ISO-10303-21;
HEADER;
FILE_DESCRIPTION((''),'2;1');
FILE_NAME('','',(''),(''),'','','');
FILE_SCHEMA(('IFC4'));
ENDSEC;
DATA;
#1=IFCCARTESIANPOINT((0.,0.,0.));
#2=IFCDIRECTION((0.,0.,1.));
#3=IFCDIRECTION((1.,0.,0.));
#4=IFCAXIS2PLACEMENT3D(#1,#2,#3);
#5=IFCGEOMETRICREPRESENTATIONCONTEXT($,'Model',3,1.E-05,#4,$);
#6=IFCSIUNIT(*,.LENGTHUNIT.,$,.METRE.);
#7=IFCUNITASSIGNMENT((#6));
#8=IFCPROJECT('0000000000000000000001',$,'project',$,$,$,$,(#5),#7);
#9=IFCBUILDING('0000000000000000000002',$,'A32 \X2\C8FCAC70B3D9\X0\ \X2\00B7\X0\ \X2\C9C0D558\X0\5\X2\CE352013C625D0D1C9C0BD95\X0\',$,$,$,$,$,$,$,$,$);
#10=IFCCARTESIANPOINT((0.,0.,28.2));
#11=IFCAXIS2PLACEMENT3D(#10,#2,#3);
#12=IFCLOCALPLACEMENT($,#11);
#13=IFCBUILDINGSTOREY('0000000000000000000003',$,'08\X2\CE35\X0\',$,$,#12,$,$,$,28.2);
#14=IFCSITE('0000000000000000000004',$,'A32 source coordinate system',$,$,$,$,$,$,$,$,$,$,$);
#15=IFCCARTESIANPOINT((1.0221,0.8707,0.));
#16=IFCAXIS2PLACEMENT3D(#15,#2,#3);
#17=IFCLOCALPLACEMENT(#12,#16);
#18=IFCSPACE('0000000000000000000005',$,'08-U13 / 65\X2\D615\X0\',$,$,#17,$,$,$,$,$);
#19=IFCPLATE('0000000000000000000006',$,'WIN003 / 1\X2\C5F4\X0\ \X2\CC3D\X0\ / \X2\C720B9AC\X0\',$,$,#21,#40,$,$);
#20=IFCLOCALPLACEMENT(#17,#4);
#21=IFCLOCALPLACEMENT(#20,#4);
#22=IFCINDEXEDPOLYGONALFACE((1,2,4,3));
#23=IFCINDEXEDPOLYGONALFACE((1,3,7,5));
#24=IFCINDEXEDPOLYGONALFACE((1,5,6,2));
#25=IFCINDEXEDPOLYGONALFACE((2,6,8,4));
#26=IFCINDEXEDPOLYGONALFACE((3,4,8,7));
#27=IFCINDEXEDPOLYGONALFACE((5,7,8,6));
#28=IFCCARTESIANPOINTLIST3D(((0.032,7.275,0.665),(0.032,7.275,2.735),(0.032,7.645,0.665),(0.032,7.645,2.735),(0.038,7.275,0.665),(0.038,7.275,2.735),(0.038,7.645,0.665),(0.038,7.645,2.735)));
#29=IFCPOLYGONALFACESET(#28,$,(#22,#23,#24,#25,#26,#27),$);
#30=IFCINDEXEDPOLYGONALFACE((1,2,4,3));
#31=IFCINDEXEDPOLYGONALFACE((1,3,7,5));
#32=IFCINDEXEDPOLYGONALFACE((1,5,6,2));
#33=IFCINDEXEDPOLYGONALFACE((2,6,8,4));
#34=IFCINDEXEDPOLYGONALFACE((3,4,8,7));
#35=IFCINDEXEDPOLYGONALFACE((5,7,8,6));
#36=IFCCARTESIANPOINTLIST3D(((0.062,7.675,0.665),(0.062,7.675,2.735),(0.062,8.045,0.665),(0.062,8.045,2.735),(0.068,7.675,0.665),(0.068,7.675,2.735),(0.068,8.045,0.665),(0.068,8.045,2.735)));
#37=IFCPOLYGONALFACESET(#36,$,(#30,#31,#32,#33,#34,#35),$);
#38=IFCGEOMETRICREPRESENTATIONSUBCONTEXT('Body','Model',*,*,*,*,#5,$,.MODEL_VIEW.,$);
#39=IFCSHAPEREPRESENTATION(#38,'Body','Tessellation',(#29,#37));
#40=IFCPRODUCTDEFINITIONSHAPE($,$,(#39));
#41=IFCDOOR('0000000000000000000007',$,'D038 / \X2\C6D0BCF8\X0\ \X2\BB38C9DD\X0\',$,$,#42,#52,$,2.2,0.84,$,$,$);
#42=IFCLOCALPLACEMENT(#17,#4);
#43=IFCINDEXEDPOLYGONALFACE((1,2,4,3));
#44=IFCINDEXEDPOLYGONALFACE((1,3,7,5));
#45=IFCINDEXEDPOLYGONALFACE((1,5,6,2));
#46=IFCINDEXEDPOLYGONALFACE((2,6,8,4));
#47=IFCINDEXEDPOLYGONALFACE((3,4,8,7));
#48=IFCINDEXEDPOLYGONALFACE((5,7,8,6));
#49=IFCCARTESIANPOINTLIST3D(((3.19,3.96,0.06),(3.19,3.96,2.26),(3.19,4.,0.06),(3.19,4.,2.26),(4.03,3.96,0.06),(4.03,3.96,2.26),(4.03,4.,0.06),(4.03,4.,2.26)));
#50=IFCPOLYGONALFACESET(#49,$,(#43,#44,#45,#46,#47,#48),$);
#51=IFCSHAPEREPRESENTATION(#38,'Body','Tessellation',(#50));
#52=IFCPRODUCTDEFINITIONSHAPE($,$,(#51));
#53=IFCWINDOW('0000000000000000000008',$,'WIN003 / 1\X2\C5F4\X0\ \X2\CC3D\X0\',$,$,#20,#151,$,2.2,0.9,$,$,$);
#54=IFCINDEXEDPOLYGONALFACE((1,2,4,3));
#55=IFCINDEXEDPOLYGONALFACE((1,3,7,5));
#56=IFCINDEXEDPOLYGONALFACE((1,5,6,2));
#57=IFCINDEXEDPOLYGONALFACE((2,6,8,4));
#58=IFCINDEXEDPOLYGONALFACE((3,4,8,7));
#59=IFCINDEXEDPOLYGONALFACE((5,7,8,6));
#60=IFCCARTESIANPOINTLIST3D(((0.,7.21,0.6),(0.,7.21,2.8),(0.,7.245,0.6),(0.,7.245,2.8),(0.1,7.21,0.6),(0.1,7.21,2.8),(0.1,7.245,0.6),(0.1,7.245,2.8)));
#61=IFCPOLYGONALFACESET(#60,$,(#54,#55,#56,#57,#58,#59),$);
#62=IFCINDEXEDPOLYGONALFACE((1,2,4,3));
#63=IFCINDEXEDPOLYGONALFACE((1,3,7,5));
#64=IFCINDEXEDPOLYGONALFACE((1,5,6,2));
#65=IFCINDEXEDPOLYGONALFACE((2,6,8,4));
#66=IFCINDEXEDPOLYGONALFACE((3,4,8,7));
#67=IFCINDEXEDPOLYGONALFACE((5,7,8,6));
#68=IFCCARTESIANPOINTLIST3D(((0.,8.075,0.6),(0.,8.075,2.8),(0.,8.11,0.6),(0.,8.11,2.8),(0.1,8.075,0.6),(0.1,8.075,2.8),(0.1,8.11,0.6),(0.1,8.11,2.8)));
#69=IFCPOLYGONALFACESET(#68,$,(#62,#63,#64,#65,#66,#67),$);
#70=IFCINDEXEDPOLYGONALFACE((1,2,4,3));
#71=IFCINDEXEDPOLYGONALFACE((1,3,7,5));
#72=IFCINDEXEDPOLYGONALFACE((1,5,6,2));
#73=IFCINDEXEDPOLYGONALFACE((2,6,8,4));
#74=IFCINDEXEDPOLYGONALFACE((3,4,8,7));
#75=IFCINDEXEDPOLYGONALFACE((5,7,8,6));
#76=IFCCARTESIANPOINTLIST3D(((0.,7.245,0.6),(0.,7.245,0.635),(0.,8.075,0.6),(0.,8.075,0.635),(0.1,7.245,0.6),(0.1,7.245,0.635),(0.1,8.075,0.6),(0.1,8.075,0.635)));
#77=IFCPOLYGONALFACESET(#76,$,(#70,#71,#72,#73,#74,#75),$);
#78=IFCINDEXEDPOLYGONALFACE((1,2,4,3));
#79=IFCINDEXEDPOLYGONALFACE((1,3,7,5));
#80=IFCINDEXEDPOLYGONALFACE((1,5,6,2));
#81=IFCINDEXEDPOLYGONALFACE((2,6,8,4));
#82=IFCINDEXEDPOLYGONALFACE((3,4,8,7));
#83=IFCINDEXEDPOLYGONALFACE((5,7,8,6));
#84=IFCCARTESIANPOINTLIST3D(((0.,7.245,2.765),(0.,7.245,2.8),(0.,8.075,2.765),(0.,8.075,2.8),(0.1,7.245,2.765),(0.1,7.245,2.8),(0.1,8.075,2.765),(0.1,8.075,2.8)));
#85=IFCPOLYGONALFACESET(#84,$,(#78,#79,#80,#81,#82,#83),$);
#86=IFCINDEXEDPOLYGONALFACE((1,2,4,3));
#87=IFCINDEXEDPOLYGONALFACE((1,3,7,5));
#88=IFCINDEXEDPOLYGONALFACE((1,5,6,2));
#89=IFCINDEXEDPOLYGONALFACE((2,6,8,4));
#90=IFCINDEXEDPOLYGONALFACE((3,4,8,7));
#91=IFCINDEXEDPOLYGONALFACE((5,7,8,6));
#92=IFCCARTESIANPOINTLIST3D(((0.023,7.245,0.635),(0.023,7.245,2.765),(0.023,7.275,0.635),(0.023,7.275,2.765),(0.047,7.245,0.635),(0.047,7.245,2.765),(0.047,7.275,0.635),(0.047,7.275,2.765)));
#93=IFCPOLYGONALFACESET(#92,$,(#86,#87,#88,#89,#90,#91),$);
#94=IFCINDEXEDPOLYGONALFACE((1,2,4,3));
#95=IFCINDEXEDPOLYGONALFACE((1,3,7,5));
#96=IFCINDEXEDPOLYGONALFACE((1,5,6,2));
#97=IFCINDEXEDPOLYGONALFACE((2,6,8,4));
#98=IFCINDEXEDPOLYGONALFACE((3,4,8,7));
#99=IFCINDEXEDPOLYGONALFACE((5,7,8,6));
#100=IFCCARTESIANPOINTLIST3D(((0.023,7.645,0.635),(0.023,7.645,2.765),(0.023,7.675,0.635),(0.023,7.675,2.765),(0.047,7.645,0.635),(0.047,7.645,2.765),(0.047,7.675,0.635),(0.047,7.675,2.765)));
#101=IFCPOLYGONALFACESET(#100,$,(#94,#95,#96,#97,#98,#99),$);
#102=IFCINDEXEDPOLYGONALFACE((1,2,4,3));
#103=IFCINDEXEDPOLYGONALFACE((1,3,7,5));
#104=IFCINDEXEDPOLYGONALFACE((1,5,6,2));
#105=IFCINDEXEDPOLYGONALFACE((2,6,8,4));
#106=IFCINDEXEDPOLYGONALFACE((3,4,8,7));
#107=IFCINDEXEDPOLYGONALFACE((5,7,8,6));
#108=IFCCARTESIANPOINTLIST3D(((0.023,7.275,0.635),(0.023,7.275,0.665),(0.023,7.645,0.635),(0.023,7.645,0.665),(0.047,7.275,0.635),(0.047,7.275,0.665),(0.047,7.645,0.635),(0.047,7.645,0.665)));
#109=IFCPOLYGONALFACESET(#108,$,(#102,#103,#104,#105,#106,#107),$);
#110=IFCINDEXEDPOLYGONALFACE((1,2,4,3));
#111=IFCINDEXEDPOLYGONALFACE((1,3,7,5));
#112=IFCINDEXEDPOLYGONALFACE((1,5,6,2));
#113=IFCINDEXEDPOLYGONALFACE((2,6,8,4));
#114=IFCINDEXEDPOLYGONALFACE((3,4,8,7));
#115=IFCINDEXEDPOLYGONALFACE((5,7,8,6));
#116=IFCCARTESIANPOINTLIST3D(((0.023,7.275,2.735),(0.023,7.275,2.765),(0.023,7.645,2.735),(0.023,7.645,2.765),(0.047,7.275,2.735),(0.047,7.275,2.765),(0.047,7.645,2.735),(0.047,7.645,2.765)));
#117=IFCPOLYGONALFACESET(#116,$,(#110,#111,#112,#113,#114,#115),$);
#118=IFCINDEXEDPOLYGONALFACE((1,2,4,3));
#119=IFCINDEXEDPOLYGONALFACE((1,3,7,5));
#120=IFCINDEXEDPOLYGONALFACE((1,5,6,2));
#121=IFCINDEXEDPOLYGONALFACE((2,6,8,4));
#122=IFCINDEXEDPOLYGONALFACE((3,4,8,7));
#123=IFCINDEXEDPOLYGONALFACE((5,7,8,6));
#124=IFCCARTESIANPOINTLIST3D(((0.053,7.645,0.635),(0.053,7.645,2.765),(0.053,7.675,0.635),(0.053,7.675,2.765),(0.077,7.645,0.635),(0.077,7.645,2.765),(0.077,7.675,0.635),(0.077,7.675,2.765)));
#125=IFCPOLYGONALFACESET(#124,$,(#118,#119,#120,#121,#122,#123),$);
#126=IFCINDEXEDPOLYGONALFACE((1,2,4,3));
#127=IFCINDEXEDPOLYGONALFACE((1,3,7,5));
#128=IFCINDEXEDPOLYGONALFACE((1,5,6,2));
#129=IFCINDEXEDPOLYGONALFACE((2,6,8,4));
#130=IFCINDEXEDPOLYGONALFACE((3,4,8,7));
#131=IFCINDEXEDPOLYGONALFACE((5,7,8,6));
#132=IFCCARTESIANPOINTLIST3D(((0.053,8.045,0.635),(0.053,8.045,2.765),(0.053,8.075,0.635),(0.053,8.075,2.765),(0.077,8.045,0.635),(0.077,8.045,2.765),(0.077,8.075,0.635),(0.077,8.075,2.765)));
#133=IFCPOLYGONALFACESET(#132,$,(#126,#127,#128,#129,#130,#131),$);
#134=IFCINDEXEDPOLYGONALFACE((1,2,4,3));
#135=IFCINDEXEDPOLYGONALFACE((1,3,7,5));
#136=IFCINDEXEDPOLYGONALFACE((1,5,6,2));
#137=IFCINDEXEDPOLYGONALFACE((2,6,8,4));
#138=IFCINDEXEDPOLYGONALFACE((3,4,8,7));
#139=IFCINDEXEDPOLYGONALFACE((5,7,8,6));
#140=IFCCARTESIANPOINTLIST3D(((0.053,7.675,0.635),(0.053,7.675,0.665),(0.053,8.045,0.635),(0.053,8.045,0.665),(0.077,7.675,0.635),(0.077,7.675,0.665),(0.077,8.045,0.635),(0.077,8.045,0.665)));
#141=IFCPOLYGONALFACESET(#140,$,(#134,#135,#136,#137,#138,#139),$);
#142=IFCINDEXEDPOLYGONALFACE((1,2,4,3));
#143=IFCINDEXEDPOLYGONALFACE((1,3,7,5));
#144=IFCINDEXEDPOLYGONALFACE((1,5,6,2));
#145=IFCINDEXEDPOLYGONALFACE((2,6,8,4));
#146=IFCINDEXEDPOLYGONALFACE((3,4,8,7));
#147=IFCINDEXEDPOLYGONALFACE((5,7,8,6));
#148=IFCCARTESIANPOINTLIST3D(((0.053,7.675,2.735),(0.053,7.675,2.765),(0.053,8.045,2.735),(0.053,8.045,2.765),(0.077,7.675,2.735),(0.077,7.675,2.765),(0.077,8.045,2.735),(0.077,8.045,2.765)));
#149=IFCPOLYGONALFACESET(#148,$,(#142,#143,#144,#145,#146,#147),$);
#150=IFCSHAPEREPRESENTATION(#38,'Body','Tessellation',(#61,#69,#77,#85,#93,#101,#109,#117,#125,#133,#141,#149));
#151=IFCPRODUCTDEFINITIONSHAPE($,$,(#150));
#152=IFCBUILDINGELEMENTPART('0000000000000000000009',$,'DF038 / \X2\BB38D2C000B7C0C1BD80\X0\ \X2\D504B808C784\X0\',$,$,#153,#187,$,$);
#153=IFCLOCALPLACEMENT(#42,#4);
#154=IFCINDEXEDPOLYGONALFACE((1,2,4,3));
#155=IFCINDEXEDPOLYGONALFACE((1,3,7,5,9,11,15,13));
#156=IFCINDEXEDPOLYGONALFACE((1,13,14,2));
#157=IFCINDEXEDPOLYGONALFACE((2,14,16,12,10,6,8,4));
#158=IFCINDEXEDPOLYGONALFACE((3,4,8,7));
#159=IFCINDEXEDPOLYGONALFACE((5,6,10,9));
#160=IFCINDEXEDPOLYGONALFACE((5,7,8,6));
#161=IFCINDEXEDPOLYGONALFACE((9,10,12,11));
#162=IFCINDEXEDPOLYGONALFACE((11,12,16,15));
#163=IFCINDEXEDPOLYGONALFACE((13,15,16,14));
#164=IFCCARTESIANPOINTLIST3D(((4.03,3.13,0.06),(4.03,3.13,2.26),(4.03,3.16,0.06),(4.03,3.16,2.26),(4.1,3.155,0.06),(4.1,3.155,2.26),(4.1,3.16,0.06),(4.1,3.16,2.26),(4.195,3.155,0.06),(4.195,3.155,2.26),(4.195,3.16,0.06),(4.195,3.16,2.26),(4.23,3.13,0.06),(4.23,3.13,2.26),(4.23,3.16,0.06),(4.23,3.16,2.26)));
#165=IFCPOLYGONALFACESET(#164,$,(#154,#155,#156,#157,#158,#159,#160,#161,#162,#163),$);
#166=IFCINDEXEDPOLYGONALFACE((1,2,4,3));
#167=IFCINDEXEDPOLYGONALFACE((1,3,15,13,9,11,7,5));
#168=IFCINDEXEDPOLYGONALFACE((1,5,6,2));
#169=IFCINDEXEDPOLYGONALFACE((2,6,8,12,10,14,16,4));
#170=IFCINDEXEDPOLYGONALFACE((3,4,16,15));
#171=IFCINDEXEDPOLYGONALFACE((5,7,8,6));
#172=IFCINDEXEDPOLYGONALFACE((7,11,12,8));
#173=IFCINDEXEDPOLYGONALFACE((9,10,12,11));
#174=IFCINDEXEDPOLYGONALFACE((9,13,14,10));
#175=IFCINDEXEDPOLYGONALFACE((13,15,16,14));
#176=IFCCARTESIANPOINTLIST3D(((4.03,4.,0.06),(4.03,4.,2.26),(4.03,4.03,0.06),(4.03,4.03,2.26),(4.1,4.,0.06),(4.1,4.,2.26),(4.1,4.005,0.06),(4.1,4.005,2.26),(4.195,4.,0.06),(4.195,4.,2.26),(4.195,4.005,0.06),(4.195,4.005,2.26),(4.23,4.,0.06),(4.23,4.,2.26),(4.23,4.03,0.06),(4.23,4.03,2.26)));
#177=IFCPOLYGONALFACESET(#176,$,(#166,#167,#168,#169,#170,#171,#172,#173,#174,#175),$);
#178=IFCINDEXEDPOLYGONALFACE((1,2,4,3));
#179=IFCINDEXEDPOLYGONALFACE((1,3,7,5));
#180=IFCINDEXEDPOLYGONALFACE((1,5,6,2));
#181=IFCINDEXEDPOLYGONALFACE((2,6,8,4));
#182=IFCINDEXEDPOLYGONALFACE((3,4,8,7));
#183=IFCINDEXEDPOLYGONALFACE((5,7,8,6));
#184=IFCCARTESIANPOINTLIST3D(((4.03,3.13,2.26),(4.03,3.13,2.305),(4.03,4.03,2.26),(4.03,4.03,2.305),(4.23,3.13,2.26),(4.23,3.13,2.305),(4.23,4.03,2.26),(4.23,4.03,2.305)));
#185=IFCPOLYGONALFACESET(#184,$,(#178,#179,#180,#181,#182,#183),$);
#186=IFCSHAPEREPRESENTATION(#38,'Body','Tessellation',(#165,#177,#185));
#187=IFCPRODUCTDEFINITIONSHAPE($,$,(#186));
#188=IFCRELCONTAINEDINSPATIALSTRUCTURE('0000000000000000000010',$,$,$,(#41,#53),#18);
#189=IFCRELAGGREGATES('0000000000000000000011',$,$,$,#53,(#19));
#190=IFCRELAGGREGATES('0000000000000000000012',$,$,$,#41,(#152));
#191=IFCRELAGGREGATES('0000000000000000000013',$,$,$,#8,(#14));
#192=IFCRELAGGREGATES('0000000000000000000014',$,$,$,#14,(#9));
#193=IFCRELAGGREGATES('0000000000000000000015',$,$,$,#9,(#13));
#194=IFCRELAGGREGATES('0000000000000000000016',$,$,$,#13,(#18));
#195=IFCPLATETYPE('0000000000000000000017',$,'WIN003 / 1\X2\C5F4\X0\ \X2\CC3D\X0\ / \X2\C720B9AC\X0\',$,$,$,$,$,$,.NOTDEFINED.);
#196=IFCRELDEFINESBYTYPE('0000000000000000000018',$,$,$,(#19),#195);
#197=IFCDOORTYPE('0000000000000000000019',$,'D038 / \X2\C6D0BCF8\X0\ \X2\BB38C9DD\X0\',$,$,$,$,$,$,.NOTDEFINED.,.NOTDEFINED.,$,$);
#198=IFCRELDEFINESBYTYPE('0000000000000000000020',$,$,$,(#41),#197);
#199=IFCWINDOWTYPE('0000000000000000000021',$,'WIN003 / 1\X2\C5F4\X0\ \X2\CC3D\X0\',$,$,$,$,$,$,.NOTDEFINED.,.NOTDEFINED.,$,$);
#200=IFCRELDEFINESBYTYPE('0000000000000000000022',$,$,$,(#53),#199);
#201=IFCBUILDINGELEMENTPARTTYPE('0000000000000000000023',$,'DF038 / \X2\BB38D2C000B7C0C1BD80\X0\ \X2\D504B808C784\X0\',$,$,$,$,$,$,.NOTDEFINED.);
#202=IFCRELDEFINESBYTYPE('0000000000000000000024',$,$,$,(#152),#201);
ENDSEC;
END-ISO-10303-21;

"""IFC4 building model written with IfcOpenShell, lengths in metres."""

from ifc_helpers import new_model, si_unit, frame, origin, origin_with_axes, place, context, subcontext, project, spatial, polyline, outline, extrude, source, transform, mapped, type_object, type_shapes, element, aggregate, save


model = new_model("IFC4")

# Units and contexts
model_context = context("Model", 3, precision=1e-05, world=origin_with_axes())
body_context = subcontext(model_context, "Body", "Model", "MODEL_VIEW")
ifc_project = project(units=[si_unit("LENGTHUNIT", "METRE")], contexts=[model_context])

# Plate
storey_placement = place(None, frame((0.0, 0.0, 28.2), z_axis=(0.0, 0.0, 1.0), x_axis=(1.0, 0.0, 0.0)))
space_placement = place(storey_placement, frame((1.0221, 0.8707, 0.0), z_axis=(0.0, 0.0, 1.0), x_axis=(1.0, 0.0, 0.0)))
plate_type_1 = type_object("IfcPlateType", Name="WIN003 / 1열 창 / 유리", PredefinedType="NOTDEFINED")
shared_shape_1 = source(origin(), body_context, "Body", "SweptSolid", [
    extrude(outline(polyline([(0.032, 7.275), (0.032, 7.645), (0.038, 7.645), (0.038, 7.275), (0.032, 7.275)])), frame((0.0, 0.0, 0.665)), (0.0, 0.0, 1.0), 2.07),
    extrude(outline(polyline([(0.062, 7.675), (0.062, 8.045), (0.068, 8.045), (0.068, 7.675), (0.062, 7.675)])), frame((0.0, 0.0, 0.665)), (0.0, 0.0, 1.0), 2.07),
])
type_shapes(plate_type_1, [shared_shape_1])
window_1_placement = place(space_placement, origin_with_axes())
plate_1_placement = place(window_1_placement, origin_with_axes())
plate_1 = element("IfcPlate", 1, at=plate_1_placement, type_object=plate_type_1, Name="WIN003 / 1열 창 / 유리", context=body_context, shape_type="MappedRepresentation", body=[
    mapped(shared_shape_1, transform((0.0, 0.0, 0.0), scale=1.0)),
])

# Site, building, storey, space
site = spatial("IfcSite", under=ifc_project, Name="A32 source coordinate system")
building = spatial("IfcBuilding", under=site, Name="A32 주거동 · 지하5층–옥탑지붕")
storey = spatial("IfcBuildingStorey", under=building, at=storey_placement, Name="08층", Elevation=28.2)
space = spatial("IfcSpace", under=storey, at=space_placement, Name="08-U13 / 65형")

# Door
door_type_1 = type_object("IfcDoorType", Name="D038 / 원본 문짝", OperationType="NOTDEFINED", PredefinedType="NOTDEFINED")
shared_shape_2 = source(origin(), body_context, "Body", "SweptSolid", [
    extrude(outline(polyline([(3.19, 3.96), (3.19, 4.0), (4.03, 4.0), (4.03, 3.96), (3.19, 3.96)])), frame((0.0, 0.0, 0.06)), (0.0, 0.0, 1.0), 2.2),
])
type_shapes(door_type_1, [shared_shape_2])
door_1_placement = place(space_placement, origin_with_axes())
door_1 = element("IfcDoor", 2, at=door_1_placement, inside=space, type_object=door_type_1, Name="D038 / 원본 문짝", OverallHeight=2.2, OverallWidth=0.84, context=body_context, shape_type="MappedRepresentation", body=[
    mapped(shared_shape_2, transform((0.0, 0.0, 0.0), scale=1.0)),
])

# Window
window_type_1 = type_object("IfcWindowType", Name="WIN003 / 1열 창", PartitioningType="NOTDEFINED", PredefinedType="NOTDEFINED")
shared_shape_3 = source(origin(), body_context, "Body", "SweptSolid", [
    extrude(outline(polyline([(0.0, 7.21), (0.0, 7.245), (0.1, 7.245), (0.1, 7.21), (0.0, 7.21)])), frame((0.0, 0.0, 0.6)), (0.0, 0.0, 1.0), 2.2),
    extrude(outline(polyline([(0.0, 8.075), (0.0, 8.11), (0.1, 8.11), (0.1, 8.075), (0.0, 8.075)])), frame((0.0, 0.0, 0.6)), (0.0, 0.0, 1.0), 2.2),
    extrude(outline(polyline([(0.0, 7.245), (0.0, 8.075), (0.1, 8.075), (0.1, 7.245), (0.0, 7.245)])), frame((0.0, 0.0, 0.6)), (0.0, 0.0, 1.0), 0.035),
    extrude(outline(polyline([(0.0, 7.245), (0.0, 8.075), (0.1, 8.075), (0.1, 7.245), (0.0, 7.245)])), frame((0.0, 0.0, 2.765)), (0.0, 0.0, 1.0), 0.035),
    extrude(outline(polyline([(0.023, 7.245), (0.023, 7.275), (0.047, 7.275), (0.047, 7.245), (0.023, 7.245)])), frame((0.0, 0.0, 0.635)), (0.0, 0.0, 1.0), 2.13),
    extrude(outline(polyline([(0.023, 7.645), (0.023, 7.675), (0.047, 7.675), (0.047, 7.645), (0.023, 7.645)])), frame((0.0, 0.0, 0.635)), (0.0, 0.0, 1.0), 2.13),
    extrude(outline(polyline([(0.023, 7.275), (0.023, 7.645), (0.047, 7.645), (0.047, 7.275), (0.023, 7.275)])), frame((0.0, 0.0, 0.635)), (0.0, 0.0, 1.0), 0.03),
    extrude(outline(polyline([(0.023, 7.275), (0.023, 7.645), (0.047, 7.645), (0.047, 7.275), (0.023, 7.275)])), frame((0.0, 0.0, 2.735)), (0.0, 0.0, 1.0), 0.03),
    extrude(outline(polyline([(0.053, 7.645), (0.053, 7.675), (0.077, 7.675), (0.077, 7.645), (0.053, 7.645)])), frame((0.0, 0.0, 0.635)), (0.0, 0.0, 1.0), 2.13),
    extrude(outline(polyline([(0.053, 8.045), (0.053, 8.075), (0.077, 8.075), (0.077, 8.045), (0.053, 8.045)])), frame((0.0, 0.0, 0.635)), (0.0, 0.0, 1.0), 2.13),
    extrude(outline(polyline([(0.053, 7.675), (0.053, 8.045), (0.077, 8.045), (0.077, 7.675), (0.053, 7.675)])), frame((0.0, 0.0, 0.635)), (0.0, 0.0, 1.0), 0.03),
    extrude(outline(polyline([(0.053, 7.675), (0.053, 8.045), (0.077, 8.045), (0.077, 7.675), (0.053, 7.675)])), frame((0.0, 0.0, 2.735)), (0.0, 0.0, 1.0), 0.03),
])
type_shapes(window_type_1, [shared_shape_3])
window_1 = element("IfcWindow", 3, at=window_1_placement, inside=space, type_object=window_type_1, Name="WIN003 / 1열 창", OverallHeight=2.2, OverallWidth=0.9, context=body_context, shape_type="MappedRepresentation", body=[
    mapped(shared_shape_3, transform((0.0, 0.0, 0.0), scale=1.0)),
])
aggregate(window_1, [plate_1])

# Building element part
building_element_part_type_1 = type_object("IfcBuildingElementPartType", Name="DF038 / 문틀·상부 프레임", PredefinedType="NOTDEFINED")
shared_shape_4 = source(origin(), body_context, "Body", "SweptSolid", [
    extrude(outline(polyline([(4.03, 3.16), (4.1, 3.16), (4.1, 3.155), (4.195, 3.155), (4.195, 3.16), (4.23, 3.16), (4.23, 3.13), (4.03, 3.13), (4.03, 3.16)])), frame((0.0, 0.0, 0.06)), (0.0, 0.0, 1.0), 2.2),
    extrude(outline(polyline([(4.23, 4.03), (4.23, 4.0), (4.195, 4.0), (4.195, 4.005), (4.1, 4.005), (4.1, 4.0), (4.03, 4.0), (4.03, 4.03), (4.23, 4.03)])), frame((0.0, 0.0, 0.06)), (0.0, 0.0, 1.0), 2.2),
    extrude(outline(polyline([(4.03, 3.13), (4.03, 4.03), (4.23, 4.03), (4.23, 3.13), (4.03, 3.13)])), frame((0.0, 0.0, 2.26)), (0.0, 0.0, 1.0), 0.045),
])
type_shapes(building_element_part_type_1, [shared_shape_4])
building_element_part_1_placement = place(door_1_placement, origin_with_axes())
building_element_part_1 = element("IfcBuildingElementPart", 4, at=building_element_part_1_placement, type_object=building_element_part_type_1, Name="DF038 / 문틀·상부 프레임", context=body_context, shape_type="MappedRepresentation", body=[
    mapped(shared_shape_4, transform((0.0, 0.0, 0.0), scale=1.0)),
])
aggregate(door_1, [building_element_part_1])

save(model, "model.ifc")
